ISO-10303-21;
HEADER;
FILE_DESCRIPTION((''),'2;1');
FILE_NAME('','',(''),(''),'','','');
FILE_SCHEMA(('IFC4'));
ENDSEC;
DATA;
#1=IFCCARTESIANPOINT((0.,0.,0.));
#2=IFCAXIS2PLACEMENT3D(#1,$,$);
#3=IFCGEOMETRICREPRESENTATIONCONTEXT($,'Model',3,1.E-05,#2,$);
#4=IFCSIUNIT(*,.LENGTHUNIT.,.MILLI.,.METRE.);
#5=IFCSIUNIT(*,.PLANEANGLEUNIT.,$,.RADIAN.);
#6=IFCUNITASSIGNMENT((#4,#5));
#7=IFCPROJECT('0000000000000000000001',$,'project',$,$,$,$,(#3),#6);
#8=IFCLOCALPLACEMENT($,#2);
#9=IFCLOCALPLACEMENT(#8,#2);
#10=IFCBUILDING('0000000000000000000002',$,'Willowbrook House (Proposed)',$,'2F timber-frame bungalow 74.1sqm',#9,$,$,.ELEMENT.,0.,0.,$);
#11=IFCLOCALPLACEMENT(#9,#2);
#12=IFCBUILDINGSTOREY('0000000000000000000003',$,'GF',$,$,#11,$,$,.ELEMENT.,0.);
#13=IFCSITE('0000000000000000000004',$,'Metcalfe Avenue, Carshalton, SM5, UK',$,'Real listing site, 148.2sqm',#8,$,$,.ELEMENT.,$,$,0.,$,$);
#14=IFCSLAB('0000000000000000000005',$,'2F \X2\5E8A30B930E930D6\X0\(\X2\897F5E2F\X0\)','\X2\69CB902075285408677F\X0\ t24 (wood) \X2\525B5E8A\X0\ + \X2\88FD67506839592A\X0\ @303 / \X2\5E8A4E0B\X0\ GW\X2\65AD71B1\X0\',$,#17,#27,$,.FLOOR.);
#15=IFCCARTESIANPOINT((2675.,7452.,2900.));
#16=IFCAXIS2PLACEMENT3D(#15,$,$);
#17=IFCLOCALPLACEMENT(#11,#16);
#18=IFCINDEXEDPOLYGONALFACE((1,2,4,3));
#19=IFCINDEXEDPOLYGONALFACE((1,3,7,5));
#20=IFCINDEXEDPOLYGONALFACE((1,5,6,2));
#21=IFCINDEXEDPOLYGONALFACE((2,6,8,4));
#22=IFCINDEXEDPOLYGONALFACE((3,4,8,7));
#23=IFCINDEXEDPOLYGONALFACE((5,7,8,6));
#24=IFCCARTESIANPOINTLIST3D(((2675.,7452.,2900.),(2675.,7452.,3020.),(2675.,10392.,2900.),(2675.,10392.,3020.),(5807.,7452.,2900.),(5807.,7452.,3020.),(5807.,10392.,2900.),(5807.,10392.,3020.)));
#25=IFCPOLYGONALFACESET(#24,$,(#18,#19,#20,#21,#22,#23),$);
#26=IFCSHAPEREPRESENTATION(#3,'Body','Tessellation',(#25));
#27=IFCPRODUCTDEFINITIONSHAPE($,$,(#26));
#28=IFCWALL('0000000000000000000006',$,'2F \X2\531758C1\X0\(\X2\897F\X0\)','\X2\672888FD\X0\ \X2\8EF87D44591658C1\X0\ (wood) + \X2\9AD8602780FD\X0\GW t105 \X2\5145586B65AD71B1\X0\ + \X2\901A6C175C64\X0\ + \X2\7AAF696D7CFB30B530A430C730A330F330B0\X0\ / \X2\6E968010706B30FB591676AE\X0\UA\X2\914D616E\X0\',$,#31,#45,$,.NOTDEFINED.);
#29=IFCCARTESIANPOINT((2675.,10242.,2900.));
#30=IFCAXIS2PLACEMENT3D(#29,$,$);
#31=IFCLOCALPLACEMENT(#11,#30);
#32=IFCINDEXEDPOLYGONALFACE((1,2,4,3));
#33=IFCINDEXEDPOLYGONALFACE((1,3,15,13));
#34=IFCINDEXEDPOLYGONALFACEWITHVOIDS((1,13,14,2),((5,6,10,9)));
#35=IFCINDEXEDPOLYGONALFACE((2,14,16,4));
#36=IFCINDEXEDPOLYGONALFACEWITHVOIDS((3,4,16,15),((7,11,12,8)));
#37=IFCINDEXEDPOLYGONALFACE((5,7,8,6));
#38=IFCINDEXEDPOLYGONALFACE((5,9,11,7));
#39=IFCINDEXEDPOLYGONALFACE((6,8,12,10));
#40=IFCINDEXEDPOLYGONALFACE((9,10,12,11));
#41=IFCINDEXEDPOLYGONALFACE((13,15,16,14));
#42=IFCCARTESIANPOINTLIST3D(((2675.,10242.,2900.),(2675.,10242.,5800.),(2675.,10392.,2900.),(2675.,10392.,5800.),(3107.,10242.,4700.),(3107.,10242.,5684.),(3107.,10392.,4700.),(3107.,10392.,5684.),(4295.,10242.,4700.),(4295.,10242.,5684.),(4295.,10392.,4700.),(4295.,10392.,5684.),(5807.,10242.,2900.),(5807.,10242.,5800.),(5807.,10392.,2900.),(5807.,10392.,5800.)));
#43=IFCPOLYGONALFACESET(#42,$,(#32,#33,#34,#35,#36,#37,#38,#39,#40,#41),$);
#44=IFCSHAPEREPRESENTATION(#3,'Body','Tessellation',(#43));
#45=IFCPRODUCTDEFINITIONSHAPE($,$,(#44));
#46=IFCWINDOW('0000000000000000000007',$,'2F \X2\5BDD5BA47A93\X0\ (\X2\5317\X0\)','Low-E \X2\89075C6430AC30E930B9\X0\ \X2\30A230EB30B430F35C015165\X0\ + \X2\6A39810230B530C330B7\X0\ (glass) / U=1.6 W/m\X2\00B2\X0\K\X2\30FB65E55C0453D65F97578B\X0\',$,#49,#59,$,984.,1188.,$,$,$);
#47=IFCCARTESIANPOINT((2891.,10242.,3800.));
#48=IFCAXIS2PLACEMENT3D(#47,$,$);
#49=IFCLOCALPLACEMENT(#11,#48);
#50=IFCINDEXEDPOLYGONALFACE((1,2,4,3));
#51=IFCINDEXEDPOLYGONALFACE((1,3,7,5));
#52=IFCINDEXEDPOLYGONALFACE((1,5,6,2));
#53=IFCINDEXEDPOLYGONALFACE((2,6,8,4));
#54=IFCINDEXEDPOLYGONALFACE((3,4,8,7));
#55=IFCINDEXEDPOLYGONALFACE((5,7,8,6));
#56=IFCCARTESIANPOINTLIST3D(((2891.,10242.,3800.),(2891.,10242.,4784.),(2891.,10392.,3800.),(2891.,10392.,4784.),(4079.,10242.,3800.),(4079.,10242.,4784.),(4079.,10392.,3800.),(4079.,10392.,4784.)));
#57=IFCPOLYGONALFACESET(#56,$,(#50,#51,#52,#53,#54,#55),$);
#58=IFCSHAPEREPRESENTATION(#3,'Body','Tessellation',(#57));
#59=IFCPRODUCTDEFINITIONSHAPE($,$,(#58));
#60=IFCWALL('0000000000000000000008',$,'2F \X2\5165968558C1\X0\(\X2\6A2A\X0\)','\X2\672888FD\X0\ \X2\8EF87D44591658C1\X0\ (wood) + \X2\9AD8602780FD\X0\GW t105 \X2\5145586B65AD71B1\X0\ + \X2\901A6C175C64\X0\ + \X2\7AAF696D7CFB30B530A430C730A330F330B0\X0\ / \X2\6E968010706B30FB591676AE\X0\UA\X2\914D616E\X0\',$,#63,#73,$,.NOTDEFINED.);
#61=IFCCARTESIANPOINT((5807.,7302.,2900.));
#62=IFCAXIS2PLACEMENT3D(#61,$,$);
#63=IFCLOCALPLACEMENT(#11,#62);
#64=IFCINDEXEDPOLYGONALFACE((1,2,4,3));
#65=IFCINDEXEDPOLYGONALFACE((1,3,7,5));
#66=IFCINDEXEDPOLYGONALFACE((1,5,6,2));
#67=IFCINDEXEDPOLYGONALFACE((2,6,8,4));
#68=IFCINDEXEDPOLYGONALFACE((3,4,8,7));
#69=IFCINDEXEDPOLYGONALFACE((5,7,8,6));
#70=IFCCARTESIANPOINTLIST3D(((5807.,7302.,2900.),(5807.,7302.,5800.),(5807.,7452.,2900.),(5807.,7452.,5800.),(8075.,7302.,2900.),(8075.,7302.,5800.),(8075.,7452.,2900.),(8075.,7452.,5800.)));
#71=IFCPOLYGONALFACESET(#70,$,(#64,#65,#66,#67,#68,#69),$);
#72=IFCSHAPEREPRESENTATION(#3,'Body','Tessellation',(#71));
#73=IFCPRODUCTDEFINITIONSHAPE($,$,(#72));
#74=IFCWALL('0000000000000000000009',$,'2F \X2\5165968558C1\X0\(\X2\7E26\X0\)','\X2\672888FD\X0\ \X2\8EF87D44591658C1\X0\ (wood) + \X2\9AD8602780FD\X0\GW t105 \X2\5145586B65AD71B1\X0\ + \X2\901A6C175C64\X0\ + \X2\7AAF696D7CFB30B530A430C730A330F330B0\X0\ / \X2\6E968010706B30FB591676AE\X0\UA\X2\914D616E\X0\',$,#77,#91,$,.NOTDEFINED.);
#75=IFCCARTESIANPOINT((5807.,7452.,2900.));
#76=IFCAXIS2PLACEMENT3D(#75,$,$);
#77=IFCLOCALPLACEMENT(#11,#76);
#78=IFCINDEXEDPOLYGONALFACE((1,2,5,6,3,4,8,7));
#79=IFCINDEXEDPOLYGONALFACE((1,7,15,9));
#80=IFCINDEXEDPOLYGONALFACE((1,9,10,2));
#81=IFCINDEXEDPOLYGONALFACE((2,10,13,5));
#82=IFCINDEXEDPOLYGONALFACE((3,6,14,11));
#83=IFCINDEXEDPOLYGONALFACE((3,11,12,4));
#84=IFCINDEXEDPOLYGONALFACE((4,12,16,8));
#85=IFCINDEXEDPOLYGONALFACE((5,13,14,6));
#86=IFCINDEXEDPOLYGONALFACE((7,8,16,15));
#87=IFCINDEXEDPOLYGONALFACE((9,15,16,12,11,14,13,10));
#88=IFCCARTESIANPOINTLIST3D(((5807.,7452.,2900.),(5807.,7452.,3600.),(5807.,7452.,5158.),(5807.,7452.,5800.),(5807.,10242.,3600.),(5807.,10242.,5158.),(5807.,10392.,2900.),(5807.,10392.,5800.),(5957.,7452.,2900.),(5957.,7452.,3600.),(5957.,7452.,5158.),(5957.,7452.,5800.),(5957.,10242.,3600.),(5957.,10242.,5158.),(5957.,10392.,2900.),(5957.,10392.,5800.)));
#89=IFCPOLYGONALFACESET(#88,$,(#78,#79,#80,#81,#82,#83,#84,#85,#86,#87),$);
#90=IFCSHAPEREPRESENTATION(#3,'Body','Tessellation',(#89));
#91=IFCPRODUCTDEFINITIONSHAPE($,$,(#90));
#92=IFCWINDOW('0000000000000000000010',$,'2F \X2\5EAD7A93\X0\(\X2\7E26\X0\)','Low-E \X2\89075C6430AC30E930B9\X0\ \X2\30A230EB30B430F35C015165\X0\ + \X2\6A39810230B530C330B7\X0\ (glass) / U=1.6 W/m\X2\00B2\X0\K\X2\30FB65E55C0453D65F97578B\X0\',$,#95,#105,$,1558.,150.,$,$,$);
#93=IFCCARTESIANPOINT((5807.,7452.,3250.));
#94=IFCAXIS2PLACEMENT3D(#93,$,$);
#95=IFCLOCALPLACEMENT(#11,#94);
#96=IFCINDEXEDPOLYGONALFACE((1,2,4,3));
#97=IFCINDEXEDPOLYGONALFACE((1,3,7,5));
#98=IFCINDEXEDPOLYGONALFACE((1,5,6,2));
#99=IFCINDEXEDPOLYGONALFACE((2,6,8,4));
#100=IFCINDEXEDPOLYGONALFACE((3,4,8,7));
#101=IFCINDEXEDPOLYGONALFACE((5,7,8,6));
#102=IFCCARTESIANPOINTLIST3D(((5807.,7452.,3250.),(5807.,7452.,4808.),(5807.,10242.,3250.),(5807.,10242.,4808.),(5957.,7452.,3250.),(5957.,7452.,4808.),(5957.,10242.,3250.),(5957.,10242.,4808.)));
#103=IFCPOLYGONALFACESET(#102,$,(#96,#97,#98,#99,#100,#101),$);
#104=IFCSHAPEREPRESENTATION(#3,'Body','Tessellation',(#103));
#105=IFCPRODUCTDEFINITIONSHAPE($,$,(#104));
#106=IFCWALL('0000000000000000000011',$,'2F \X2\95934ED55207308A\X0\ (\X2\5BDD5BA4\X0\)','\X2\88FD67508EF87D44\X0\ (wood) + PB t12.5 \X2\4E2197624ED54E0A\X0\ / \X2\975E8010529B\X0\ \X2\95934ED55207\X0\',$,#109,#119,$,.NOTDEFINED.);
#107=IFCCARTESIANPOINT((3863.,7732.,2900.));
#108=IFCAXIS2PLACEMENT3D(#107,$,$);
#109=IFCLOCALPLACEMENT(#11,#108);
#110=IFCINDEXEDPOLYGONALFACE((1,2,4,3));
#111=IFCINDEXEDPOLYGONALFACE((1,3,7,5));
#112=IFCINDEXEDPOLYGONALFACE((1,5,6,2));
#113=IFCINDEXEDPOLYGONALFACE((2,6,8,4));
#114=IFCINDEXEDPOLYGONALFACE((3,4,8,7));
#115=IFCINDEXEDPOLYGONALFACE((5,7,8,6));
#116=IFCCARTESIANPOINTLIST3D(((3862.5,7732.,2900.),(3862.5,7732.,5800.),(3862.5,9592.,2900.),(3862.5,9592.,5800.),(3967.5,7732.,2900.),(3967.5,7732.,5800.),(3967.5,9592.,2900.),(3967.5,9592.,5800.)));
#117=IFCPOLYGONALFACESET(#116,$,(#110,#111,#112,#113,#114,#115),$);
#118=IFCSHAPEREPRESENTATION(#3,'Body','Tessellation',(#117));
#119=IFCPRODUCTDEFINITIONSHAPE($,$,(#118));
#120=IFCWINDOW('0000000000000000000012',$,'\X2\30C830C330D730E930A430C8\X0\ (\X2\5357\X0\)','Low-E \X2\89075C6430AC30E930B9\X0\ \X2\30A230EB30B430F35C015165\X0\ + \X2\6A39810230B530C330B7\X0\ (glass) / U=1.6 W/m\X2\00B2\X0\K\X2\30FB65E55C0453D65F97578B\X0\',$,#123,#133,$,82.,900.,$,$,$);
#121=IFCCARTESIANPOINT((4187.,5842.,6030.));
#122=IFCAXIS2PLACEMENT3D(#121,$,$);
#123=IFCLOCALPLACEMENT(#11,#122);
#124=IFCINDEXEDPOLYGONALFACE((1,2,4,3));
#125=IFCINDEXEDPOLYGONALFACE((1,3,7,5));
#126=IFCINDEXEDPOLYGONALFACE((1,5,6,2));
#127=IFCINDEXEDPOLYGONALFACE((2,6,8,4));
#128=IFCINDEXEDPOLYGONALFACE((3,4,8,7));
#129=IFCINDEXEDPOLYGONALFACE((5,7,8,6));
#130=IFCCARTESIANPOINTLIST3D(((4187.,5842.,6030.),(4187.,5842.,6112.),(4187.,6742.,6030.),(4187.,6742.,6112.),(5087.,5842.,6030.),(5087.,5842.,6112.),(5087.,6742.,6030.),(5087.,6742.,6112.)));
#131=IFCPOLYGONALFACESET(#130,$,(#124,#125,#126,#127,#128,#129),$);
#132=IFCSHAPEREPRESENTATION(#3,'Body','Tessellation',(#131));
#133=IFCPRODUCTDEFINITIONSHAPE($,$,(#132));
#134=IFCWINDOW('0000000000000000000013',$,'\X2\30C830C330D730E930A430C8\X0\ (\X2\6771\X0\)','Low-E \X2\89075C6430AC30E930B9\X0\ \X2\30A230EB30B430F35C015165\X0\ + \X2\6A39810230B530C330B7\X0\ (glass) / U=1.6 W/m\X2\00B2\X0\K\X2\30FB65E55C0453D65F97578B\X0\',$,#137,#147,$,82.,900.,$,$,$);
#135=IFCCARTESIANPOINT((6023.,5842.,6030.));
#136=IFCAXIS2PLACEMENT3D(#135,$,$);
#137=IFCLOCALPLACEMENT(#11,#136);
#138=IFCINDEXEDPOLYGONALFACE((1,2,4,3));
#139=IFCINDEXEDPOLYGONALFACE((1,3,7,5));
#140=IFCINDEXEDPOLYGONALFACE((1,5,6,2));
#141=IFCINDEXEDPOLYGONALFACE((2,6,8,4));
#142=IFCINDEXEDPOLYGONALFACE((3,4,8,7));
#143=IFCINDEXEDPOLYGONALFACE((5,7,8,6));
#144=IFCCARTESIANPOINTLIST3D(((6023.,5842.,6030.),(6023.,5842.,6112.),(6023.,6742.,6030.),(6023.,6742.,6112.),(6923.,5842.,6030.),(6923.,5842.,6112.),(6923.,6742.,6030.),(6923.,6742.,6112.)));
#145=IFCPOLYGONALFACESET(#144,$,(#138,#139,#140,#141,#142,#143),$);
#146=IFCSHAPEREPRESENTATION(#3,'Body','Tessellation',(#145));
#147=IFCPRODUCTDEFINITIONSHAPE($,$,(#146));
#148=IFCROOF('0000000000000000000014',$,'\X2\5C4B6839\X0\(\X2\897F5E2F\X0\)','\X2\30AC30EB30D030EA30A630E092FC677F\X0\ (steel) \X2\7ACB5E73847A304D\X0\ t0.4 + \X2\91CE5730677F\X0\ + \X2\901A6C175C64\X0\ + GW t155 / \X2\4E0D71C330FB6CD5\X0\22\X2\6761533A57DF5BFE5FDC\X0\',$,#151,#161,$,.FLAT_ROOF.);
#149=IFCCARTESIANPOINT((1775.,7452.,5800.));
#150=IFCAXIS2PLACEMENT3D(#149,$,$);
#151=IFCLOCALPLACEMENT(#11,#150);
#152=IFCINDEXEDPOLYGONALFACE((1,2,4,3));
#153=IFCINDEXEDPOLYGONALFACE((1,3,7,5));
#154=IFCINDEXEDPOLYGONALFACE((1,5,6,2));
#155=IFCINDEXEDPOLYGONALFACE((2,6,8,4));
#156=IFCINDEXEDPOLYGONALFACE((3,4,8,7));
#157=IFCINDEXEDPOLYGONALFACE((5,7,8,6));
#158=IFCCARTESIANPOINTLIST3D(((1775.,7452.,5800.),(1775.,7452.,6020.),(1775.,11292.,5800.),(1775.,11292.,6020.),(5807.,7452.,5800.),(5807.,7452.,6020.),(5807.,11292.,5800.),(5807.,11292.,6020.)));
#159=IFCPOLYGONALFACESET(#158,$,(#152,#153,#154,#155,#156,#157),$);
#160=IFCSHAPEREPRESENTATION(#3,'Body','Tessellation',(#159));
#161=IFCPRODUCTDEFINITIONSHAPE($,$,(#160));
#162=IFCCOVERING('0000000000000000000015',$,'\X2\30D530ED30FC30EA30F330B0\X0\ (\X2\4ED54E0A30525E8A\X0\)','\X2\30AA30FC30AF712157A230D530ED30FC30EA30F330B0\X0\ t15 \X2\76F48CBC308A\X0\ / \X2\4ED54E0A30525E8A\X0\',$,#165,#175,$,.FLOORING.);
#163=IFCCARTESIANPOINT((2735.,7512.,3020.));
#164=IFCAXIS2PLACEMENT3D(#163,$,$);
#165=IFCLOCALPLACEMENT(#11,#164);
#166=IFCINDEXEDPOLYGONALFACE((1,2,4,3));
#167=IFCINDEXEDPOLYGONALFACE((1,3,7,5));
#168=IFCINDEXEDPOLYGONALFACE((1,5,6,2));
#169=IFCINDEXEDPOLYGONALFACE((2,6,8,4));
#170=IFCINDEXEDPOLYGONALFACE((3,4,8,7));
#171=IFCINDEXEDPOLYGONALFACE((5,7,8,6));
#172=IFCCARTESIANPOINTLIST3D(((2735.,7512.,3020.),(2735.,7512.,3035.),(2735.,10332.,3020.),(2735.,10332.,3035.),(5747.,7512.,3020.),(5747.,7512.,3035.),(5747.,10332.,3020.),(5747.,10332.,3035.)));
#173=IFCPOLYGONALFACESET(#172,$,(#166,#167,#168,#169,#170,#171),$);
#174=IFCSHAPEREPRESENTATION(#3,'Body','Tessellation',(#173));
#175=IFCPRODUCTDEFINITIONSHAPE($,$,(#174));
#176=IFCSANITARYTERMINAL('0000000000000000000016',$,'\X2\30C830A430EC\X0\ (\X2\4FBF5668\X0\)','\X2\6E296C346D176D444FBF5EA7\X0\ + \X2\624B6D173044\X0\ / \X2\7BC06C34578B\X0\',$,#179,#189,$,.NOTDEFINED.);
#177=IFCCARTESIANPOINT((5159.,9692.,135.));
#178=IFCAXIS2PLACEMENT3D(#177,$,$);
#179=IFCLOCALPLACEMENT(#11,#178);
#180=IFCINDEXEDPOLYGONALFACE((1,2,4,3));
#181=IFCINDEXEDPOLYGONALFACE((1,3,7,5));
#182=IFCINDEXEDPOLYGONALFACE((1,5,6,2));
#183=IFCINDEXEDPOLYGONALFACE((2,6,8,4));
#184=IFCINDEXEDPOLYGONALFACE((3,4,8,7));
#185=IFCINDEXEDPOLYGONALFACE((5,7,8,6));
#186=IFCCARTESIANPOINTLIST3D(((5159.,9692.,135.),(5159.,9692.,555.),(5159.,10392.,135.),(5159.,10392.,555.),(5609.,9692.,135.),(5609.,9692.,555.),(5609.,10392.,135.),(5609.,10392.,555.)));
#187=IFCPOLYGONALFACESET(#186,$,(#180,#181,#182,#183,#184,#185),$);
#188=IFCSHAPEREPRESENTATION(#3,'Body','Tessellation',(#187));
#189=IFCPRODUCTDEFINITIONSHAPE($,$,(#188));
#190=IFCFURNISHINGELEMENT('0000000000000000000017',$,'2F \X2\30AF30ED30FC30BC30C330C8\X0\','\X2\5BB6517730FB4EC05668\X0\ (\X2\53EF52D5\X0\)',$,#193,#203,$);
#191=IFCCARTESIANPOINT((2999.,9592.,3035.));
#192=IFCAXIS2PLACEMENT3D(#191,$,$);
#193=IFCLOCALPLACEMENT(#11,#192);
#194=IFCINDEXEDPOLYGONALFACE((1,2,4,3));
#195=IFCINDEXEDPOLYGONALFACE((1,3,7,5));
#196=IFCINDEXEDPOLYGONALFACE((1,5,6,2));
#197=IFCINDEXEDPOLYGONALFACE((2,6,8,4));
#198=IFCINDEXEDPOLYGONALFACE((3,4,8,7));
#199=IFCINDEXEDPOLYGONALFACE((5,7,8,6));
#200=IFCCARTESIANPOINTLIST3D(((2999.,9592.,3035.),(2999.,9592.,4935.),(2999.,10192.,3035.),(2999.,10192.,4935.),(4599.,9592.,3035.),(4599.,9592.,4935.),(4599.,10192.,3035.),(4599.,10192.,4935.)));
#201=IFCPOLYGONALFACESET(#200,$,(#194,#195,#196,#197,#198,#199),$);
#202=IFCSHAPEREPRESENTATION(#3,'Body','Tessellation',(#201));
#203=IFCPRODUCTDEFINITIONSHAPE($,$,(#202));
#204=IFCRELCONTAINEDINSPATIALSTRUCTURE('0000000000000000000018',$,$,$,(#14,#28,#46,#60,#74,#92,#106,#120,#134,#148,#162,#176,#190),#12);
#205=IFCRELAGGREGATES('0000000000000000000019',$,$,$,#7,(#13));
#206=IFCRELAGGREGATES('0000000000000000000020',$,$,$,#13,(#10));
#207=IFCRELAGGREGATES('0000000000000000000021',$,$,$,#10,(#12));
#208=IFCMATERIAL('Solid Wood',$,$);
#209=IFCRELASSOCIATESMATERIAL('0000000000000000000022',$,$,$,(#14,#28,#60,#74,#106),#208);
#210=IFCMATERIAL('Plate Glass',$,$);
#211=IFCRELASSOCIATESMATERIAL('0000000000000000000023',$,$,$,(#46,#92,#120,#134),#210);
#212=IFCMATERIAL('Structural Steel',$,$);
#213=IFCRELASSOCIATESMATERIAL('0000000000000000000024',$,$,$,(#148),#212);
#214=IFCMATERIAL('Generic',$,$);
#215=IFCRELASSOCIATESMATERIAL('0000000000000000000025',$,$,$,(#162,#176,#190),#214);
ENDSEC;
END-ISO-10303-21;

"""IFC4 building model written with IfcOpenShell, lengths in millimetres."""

from ifc_helpers import new_model, si_unit, frame, frame_2d, origin, place, context, project, spatial, rectangle, extrude, material, element, fill, save


model = new_model("IFC4")

# Units and contexts
model_context = context("Model", 3, precision=1e-05, world=origin())
ifc_project = project(units=[si_unit("LENGTHUNIT", "METRE", prefix="MILLI"), si_unit("PLANEANGLEUNIT", "RADIAN")], contexts=[model_context])

# Site, building, storey
site_placement = place(None, origin())
site = spatial("IfcSite", under=ifc_project, at=site_placement, Name="Metcalfe Avenue, Carshalton, SM5, UK", ObjectType="Real listing site, 148.2sqm", CompositionType="ELEMENT", RefElevation=0.0)
building_placement = place(site_placement, origin())
building = spatial("IfcBuilding", under=site, at=building_placement, Name="Willowbrook House (Proposed)", ObjectType="2F timber-frame bungalow 74.1sqm", CompositionType="ELEMENT", ElevationOfRefHeight=0.0, ElevationOfTerrain=0.0)
storey_placement = place(building_placement, origin())
storey = spatial("IfcBuildingStorey", under=building, at=storey_placement, Name="GF", CompositionType="ELEMENT", Elevation=0.0)

# Slab
ifc_material_1 = material(Name="Solid Wood")
slab_placement = place(storey_placement, frame((2675.0, 7452.0, 2900.0)))
element("IfcSlab", 1, at=slab_placement, inside=storey, material=ifc_material_1, Name="2F 床スラブ(西帯)", Description="構造用合板 t24 (wood) 剛床 + 製材根太 @303 / 床下 GW断熱", PredefinedType="FLOOR", context=model_context, shape_type="SweptSolid", body=[
    extrude(rectangle(XDim=3132.0, YDim=2940.0, at=frame_2d((1566.0, 1470.0))), frame((2675.0, 7452.0, 2900.0)), (0.0, 0.0, 1.0), 120.0),
])

# Wall, opening, window
wall_1_placement = place(storey_placement, frame((2675.0, 10242.0, 2900.0)))
wall_1 = element("IfcWall", 2, at=wall_1_placement, inside=storey, material=ifc_material_1, Name="2F 北壁(西)", Description="木製 軸組外壁 (wood) + 高性能GW t105 充填断熱 + 通気層 + 窯業系サイディング / 準耐火・外皮UA配慮", PredefinedType="NOTDEFINED", context=model_context, shape_type="SweptSolid", body=[
    extrude(rectangle(XDim=3132.0, YDim=150.0, at=frame_2d((1566.0, 75.0))), frame((2675.0, 10242.0, 2900.0)), (0.0, 0.0, 1.0), 2900.0),
])
opening_1_placement = place(storey_placement, frame((2891.0, 10242.0, 3800.0)))
opening_1 = element("IfcOpeningElement", 3, at=opening_1_placement, cuts=wall_1, PredefinedType="NOTDEFINED", context=model_context, shape_type="SweptSolid", body=[
    extrude(rectangle(XDim=1188.0, YDim=150.0, at=frame_2d((594.0, 75.0))), frame((2891.0, 10242.0, 3800.0)), (0.0, 0.0, 1.0), 984.0),
])
ifc_material_2 = material(Name="Plate Glass")
window_1_placement = place(storey_placement, frame((2891.0, 10242.0, 3800.0)))
window_1 = element("IfcWindow", 4, at=window_1_placement, inside=storey, material=ifc_material_2, Name="2F 寝室窓 (北)", Description="Low-E 複層ガラス アルゴン封入 + 樹脂サッシ (glass) / U=1.6 W/m²K・日射取得型", OverallHeight=984.0, OverallWidth=1188.0, context=model_context, shape_type="SweptSolid", body=[
    extrude(rectangle(XDim=1188.0, YDim=150.0, at=frame_2d((594.0, 75.0))), frame((2891.0, 10242.0, 3800.0)), (0.0, 0.0, 1.0), 984.0),
])
fill(opening_1, window_1)

# Wall
wall_2_placement = place(storey_placement, frame((5807.0, 7302.0, 2900.0)))
element("IfcWall", 5, at=wall_2_placement, inside=storey, material=ifc_material_1, Name="2F 入隅壁(横)", Description="木製 軸組外壁 (wood) + 高性能GW t105 充填断熱 + 通気層 + 窯業系サイディング / 準耐火・外皮UA配慮", PredefinedType="NOTDEFINED", context=model_context, shape_type="SweptSolid", body=[
    extrude(rectangle(XDim=2268.0, YDim=150.0, at=frame_2d((1134.0, 75.0))), frame((5807.0, 7302.0, 2900.0)), (0.0, 0.0, 1.0), 2900.0),
])

# Wall, opening, window
wall_3_placement = place(storey_placement, frame((5807.0, 7452.0, 2900.0)))
wall_3 = element("IfcWall", 6, at=wall_3_placement, inside=storey, material=ifc_material_1, Name="2F 入隅壁(縦)", Description="木製 軸組外壁 (wood) + 高性能GW t105 充填断熱 + 通気層 + 窯業系サイディング / 準耐火・外皮UA配慮", PredefinedType="NOTDEFINED", context=model_context, shape_type="SweptSolid", body=[
    extrude(rectangle(XDim=150.0, YDim=2940.0, at=frame_2d((75.0, 1470.0))), frame((5807.0, 7452.0, 2900.0)), (0.0, 0.0, 1.0), 2900.0),
])
opening_2_placement = place(storey_placement, frame((5807.0, 7452.0, 3250.0)))
opening_2 = element("IfcOpeningElement", 7, at=opening_2_placement, cuts=wall_3, PredefinedType="NOTDEFINED", context=model_context, shape_type="SweptSolid", body=[
    extrude(rectangle(XDim=150.0, YDim=2790.0, at=frame_2d((75.0, 1395.0))), frame((5807.0, 7452.0, 3250.0)), (0.0, 0.0, 1.0), 1558.0),
])
window_2_placement = place(storey_placement, frame((5807.0, 7452.0, 3250.0)))
window_2 = element("IfcWindow", 8, at=window_2_placement, inside=storey, material=ifc_material_2, Name="2F 庭窓(縦)", Description="Low-E 複層ガラス アルゴン封入 + 樹脂サッシ (glass) / U=1.6 W/m²K・日射取得型", OverallHeight=1558.0, OverallWidth=150.0, context=model_context, shape_type="SweptSolid", body=[
    extrude(rectangle(XDim=150.0, YDim=2790.0, at=frame_2d((75.0, 1395.0))), frame((5807.0, 7452.0, 3250.0)), (0.0, 0.0, 1.0), 1558.0),
])
fill(opening_2, window_2)

# Wall
wall_4_placement = place(storey_placement, frame((3863.0, 7732.0, 2900.0)))
element("IfcWall", 9, at=wall_4_placement, inside=storey, material=ifc_material_1, Name="2F 間仕切り (寝室)", Description="製材軸組 (wood) + PB t12.5 両面仕上 / 非耐力 間仕切", PredefinedType="NOTDEFINED", context=model_context, shape_type="SweptSolid", body=[
    extrude(rectangle(XDim=105.0, YDim=1860.0, at=frame_2d((52.0, 930.0))), frame((3863.0, 7732.0, 2900.0)), (0.0, 0.0, 1.0), 2900.0),
])

# Windows
window_3_placement = place(storey_placement, frame((4187.0, 5842.0, 6030.0)))
element("IfcWindow", 10, at=window_3_placement, inside=storey, material=ifc_material_2, Name="トップライト (南)", Description="Low-E 複層ガラス アルゴン封入 + 樹脂サッシ (glass) / U=1.6 W/m²K・日射取得型", OverallHeight=82.0, OverallWidth=900.0, context=model_context, shape_type="SweptSolid", body=[
    extrude(rectangle(XDim=900.0, YDim=900.0, at=frame_2d((450.0, 450.0))), frame((4187.0, 5842.0, 6030.0)), (0.0, 0.0, 1.0), 82.0),
])
window_4_placement = place(storey_placement, frame((6023.0, 5842.0, 6030.0)))
element("IfcWindow", 11, at=window_4_placement, inside=storey, material=ifc_material_2, Name="トップライト (東)", Description="Low-E 複層ガラス アルゴン封入 + 樹脂サッシ (glass) / U=1.6 W/m²K・日射取得型", OverallHeight=82.0, OverallWidth=900.0, context=model_context, shape_type="SweptSolid", body=[
    extrude(rectangle(XDim=900.0, YDim=900.0, at=frame_2d((450.0, 450.0))), frame((6023.0, 5842.0, 6030.0)), (0.0, 0.0, 1.0), 82.0),
])

# Roof
ifc_material_3 = material(Name="Structural Steel")
for number, where, name in (
    (12, (1775.0, 7452.0, 5800.0), "屋根(西帯)"),
):
    element("IfcRoof", number, at=place(storey_placement, frame(where)), inside=storey, material=ifc_material_3, Name=name, Description="ガルバリウム鋼板 (steel) 立平葺き t0.4 + 野地板 + 通気層 + GW t155 / 不燃・法22条区域対応", PredefinedType="FLAT_ROOF", context=model_context, shape_type="SweptSolid", body=[
        extrude(rectangle(XDim=4032.0, YDim=3840.0, at=frame_2d((2016.0, 1920.0))), frame((1775.0, 7452.0, 5800.0)), (0.0, 0.0, 1.0), 220.0),
    ])

# Covering
ifc_material_4 = material(Name="Generic")
covering_placement = place(storey_placement, frame((2735.0, 7512.0, 3020.0)))
element("IfcCovering", 13, at=covering_placement, inside=storey, material=ifc_material_4, Name="フローリング (仕上げ床)", Description="オーク無垢フローリング t15 直貼り / 仕上げ床", PredefinedType="FLOORING", context=model_context, shape_type="SweptSolid", body=[
    extrude(rectangle(XDim=3012.0, YDim=2820.0, at=frame_2d((1506.0, 1410.0))), frame((2735.0, 7512.0, 3020.0)), (0.0, 0.0, 1.0), 15.0),
])

# Sanitary terminal
sanitary_terminal_placement = place(storey_placement, frame((5159.0, 9692.0, 135.0)))
element("IfcSanitaryTerminal", 14, at=sanitary_terminal_placement, inside=storey, material=ifc_material_4, Name="トイレ (便器)", Description="温水洗浄便座 + 手洗い / 節水型", PredefinedType="NOTDEFINED", context=model_context, shape_type="SweptSolid", body=[
    extrude(rectangle(XDim=450.0, YDim=700.0, at=frame_2d((225.0, 350.0))), frame((5159.0, 9692.0, 135.0)), (0.0, 0.0, 1.0), 420.0),
])

# Furnishing element
furnishing_1_placement = place(storey_placement, frame((2999.0, 9592.0, 3035.0)))
element("IfcFurnishingElement", 15, at=furnishing_1_placement, inside=storey, material=ifc_material_4, Name="2F クローゼット", Description="家具・什器 (可動)", context=model_context, shape_type="SweptSolid", body=[
    extrude(rectangle(XDim=1600.0, YDim=600.0, at=frame_2d((800.0, 300.0))), frame((2999.0, 9592.0, 3035.0)), (0.0, 0.0, 1.0), 1900.0),
])

save(model, "model.ifc")
